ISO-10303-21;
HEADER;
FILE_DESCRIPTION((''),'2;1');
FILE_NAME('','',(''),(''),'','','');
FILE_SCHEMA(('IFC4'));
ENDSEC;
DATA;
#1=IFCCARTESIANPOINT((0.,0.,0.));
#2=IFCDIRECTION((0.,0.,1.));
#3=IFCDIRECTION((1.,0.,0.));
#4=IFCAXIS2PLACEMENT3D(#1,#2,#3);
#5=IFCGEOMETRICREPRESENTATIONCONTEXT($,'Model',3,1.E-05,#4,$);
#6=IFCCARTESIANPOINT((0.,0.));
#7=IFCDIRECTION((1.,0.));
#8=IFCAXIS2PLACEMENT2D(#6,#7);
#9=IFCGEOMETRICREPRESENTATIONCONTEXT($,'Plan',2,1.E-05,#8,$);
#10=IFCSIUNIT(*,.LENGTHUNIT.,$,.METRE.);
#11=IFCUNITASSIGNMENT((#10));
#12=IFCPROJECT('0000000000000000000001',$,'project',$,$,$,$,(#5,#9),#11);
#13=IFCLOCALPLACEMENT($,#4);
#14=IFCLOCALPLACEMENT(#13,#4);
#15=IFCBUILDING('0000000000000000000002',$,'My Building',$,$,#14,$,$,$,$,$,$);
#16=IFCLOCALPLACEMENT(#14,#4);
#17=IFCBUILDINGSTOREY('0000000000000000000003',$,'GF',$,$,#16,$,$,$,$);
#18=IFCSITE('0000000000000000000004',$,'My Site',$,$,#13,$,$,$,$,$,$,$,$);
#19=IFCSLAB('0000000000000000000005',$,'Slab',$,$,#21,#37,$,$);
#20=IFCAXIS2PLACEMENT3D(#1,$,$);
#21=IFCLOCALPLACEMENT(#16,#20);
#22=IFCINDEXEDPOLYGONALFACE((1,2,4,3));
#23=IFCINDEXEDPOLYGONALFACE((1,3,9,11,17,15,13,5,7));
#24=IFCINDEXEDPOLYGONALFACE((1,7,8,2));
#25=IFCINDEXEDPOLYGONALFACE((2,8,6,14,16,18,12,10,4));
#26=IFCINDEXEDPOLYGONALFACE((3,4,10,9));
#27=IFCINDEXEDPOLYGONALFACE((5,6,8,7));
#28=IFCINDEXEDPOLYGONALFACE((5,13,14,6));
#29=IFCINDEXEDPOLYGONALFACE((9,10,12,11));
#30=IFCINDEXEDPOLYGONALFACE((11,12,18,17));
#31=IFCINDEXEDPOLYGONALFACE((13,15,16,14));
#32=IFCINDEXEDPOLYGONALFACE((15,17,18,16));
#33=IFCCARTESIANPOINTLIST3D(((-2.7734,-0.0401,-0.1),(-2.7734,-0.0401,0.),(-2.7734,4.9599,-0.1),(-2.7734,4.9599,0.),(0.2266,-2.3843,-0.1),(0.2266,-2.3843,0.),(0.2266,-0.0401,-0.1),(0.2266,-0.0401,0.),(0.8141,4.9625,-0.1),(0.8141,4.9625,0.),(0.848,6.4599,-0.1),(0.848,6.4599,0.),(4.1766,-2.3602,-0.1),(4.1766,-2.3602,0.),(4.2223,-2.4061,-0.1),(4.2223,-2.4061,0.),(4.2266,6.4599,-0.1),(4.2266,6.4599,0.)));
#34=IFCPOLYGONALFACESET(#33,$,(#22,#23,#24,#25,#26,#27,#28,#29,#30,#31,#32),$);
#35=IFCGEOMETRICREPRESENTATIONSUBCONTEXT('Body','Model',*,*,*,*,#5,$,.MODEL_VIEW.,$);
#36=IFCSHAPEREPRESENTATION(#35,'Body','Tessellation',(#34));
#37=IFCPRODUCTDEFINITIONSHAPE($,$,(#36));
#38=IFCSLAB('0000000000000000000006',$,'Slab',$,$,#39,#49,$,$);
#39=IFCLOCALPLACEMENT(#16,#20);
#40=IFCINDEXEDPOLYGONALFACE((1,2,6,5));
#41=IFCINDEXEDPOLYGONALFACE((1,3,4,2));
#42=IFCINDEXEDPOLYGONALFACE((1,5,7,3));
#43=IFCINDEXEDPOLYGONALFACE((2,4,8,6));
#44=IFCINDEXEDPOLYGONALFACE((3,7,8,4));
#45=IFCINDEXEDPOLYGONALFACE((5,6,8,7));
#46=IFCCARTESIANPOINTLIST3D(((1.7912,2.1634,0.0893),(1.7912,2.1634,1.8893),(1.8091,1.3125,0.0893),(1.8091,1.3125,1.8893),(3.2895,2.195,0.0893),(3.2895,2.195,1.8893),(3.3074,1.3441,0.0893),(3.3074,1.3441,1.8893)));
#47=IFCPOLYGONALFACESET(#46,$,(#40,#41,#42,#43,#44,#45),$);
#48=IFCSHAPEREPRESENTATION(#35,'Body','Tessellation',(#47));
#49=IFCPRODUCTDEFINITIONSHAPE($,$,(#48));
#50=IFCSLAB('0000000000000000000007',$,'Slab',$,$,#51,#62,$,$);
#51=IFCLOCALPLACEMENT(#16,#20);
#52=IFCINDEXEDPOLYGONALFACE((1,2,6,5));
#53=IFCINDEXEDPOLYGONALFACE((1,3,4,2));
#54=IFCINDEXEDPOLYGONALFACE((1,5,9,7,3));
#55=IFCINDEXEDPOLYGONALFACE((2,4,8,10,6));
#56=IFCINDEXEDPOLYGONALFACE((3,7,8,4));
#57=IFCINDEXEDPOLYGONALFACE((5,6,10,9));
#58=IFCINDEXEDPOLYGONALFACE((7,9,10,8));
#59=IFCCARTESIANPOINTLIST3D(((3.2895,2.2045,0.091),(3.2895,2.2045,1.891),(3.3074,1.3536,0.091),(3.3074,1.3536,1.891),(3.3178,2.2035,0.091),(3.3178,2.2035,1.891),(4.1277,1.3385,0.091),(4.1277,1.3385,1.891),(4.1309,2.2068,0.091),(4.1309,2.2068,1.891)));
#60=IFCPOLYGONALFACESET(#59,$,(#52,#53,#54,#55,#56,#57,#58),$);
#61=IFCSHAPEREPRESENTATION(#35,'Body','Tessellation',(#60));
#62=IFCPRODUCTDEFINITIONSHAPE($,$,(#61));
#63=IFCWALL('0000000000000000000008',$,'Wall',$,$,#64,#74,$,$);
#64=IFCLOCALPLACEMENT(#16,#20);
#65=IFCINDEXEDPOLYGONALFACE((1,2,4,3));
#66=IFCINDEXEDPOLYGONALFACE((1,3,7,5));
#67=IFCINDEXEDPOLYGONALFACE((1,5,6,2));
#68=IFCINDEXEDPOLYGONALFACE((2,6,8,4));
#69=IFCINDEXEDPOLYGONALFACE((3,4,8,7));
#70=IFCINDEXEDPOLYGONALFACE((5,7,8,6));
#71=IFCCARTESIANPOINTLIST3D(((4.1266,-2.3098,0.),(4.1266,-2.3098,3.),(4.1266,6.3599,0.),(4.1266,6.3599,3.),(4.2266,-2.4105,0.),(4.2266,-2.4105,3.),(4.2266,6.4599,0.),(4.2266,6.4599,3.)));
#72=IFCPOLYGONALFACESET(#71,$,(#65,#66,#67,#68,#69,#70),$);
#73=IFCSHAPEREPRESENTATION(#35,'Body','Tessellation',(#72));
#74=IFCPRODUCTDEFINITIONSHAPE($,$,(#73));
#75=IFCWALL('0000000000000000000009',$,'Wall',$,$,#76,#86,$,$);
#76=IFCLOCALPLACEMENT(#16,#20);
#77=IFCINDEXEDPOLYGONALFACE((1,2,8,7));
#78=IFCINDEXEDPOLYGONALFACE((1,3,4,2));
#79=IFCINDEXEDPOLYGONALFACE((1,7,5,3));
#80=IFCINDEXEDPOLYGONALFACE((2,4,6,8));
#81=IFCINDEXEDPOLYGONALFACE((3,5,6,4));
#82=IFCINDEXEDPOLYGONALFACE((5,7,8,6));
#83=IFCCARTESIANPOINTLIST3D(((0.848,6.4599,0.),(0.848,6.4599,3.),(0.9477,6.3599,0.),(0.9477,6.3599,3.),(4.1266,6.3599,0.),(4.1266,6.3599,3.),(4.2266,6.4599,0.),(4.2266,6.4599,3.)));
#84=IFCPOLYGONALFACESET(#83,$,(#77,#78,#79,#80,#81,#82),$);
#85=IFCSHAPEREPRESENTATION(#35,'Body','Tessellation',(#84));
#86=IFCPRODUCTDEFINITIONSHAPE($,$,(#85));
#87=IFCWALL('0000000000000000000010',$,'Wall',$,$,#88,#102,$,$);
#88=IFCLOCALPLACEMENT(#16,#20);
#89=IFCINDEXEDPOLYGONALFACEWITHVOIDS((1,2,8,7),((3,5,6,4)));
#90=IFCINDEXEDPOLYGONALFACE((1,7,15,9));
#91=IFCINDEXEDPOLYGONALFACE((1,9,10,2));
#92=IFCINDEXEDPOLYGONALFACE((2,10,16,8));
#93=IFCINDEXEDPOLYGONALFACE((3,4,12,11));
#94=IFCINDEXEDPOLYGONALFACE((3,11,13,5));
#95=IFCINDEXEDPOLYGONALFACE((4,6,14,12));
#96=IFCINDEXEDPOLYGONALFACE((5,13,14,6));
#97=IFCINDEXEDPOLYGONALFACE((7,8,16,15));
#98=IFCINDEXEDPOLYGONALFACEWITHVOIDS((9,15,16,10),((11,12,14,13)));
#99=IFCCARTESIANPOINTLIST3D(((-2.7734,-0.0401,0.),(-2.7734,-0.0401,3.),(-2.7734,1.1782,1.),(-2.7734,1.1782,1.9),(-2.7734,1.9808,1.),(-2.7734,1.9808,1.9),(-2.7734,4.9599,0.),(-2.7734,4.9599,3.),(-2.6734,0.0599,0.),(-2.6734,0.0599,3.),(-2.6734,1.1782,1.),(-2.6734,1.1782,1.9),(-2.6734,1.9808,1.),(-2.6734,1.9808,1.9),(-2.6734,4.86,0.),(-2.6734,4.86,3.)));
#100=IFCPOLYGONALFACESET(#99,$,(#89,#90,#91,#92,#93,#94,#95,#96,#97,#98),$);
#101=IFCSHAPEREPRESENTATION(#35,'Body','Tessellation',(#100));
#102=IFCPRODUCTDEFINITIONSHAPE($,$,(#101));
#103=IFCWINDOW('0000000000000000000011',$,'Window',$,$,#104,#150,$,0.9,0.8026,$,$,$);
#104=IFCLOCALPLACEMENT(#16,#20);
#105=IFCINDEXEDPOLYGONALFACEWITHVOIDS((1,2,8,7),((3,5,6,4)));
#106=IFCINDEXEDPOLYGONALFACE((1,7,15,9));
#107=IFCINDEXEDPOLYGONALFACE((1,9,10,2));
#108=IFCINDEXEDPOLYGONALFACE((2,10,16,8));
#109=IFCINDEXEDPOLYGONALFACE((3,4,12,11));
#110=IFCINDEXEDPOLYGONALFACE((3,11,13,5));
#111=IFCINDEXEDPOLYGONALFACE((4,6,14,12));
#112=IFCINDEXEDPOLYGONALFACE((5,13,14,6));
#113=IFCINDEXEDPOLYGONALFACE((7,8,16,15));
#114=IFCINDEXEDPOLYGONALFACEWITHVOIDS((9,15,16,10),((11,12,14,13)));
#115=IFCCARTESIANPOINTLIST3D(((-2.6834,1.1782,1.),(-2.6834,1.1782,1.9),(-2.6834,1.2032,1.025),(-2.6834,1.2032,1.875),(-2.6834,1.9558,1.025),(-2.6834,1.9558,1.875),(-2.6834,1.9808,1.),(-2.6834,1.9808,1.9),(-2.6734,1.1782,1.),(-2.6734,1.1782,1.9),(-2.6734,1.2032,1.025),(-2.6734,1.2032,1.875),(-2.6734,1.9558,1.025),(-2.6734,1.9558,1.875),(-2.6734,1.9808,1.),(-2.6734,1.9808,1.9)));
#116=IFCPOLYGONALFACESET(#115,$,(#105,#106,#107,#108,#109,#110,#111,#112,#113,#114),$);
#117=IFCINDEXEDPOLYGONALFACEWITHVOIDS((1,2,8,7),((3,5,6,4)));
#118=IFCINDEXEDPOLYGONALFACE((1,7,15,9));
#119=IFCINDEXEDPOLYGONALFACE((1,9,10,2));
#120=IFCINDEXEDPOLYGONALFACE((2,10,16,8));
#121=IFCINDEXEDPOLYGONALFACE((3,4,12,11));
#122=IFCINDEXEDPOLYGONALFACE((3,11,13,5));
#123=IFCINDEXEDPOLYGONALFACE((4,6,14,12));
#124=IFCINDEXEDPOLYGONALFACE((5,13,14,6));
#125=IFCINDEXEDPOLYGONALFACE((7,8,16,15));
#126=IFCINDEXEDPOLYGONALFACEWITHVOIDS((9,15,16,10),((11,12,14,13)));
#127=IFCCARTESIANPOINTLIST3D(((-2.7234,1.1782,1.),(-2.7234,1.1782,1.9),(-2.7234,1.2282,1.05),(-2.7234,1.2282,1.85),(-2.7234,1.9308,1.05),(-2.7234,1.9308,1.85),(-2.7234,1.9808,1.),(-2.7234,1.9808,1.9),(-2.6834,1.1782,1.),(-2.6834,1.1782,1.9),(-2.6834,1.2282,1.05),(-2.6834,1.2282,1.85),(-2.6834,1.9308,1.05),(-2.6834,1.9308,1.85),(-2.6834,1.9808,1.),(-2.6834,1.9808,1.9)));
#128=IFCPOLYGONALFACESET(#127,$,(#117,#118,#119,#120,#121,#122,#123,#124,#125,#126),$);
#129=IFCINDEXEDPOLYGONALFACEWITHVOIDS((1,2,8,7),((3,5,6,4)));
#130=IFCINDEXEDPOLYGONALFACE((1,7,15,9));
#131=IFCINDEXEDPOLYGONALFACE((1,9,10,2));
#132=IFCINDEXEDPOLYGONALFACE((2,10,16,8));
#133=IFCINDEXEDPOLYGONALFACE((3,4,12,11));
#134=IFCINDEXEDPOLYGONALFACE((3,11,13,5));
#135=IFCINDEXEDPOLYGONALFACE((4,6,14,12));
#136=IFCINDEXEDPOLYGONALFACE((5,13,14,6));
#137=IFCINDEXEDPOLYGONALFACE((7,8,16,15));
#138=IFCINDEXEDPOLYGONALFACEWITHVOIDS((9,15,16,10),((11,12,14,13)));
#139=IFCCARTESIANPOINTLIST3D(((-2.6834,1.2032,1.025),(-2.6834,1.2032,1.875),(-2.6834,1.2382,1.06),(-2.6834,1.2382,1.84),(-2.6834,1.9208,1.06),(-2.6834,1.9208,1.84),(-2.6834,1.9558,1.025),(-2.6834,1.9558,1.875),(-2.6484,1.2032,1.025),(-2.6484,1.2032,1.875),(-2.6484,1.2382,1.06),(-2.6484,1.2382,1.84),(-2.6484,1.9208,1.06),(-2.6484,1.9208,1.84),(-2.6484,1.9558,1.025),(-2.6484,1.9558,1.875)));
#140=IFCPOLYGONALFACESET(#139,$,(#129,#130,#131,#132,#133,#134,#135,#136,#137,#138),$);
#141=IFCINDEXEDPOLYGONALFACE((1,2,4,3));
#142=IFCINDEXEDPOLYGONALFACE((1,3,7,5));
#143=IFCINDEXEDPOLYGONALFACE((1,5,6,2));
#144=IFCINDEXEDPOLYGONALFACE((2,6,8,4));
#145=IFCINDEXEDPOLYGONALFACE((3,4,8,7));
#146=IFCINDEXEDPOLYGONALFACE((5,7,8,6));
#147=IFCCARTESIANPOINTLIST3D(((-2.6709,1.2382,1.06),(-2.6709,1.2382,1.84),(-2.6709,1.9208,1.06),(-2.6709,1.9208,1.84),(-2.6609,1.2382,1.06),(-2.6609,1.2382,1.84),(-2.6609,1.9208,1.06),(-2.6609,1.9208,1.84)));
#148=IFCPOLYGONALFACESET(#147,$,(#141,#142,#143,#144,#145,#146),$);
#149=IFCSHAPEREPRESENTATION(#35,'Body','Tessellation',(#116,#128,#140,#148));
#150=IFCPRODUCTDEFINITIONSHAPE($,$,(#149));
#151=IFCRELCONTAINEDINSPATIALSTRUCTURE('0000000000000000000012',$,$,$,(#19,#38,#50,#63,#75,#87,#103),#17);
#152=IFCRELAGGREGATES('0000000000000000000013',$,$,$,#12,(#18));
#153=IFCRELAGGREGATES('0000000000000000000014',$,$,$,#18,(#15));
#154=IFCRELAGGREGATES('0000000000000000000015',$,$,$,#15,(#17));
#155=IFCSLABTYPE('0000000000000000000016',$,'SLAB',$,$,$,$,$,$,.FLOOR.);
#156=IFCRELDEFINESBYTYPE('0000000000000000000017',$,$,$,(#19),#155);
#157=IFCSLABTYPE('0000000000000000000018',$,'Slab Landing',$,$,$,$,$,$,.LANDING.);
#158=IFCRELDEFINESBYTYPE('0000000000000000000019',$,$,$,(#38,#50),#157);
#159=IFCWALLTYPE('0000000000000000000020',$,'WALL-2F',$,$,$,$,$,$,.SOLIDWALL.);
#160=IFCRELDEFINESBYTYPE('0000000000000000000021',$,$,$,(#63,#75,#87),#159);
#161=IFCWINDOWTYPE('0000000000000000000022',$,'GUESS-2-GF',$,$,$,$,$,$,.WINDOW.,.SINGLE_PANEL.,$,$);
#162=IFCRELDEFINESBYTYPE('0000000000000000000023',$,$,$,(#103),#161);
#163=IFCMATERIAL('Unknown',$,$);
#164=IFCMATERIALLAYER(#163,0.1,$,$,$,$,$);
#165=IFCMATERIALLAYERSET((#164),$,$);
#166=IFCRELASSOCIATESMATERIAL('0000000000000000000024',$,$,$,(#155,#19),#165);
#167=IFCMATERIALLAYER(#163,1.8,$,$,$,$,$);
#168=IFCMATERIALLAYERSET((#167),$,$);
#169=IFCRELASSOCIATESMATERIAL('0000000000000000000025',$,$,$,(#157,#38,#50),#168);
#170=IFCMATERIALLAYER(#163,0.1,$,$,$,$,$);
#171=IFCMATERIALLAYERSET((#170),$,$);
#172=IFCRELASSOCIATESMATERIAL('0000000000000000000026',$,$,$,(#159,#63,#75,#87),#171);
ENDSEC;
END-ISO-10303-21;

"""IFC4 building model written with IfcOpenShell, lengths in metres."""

from ifc_helpers import new_model, entity, si_unit, frame, origin_with_axes, origin_2d_with_axis, place, context, subcontext, project, spatial, line, indexed_curve, outline, extrude, shape, source, transform, mapped, material, layer, layer_set, layer_usage, type_object, type_shapes, element, fill, save


model = new_model("IFC4")

# Units and contexts
model_context = context("Model", 3, precision=1e-05, world=origin_with_axes())
plan_context = context("Plan", 2, precision=1e-05, world=origin_2d_with_axis())
body_context_1 = subcontext(model_context, "Body", "Model", "MODEL_VIEW")
body_context_2 = subcontext(plan_context, "Body", "Plan", "PLAN_VIEW")
ifc_project = project(units=[si_unit("LENGTHUNIT", "METRE")], contexts=[model_context, plan_context])

# Site, building, storey
site_placement = place(None, origin_with_axes())
site = spatial("IfcSite", under=ifc_project, at=site_placement, Name="My Site")
building_placement = place(site_placement, origin_with_axes())
building = spatial("IfcBuilding", under=site, at=building_placement, Name="My Building")
storey_placement = place(building_placement, origin_with_axes())
storey = spatial("IfcBuildingStorey", under=building, at=storey_placement, Name="GF")

# Slabs
ifc_material_1 = material(Name="Unknown")
ifc_layer_1 = layer(ifc_material_1, 0.1)
ifc_layer_set_1 = layer_set([ifc_layer_1])
ifc_layer_usage_1 = layer_usage(ifc_layer_set_1, "AXIS3", "POSITIVE", -0.1)
slab_type_1 = type_object("IfcSlabType", Name="SLAB", PredefinedType="FLOOR", material=ifc_layer_set_1)
slab_1_placement = place(storey_placement, frame((4.2223, -2.4061, 0.0), z_axis=(0.0, 0.0, 1.0), x_axis=(1.0, 0.0, 0.0)))
element("IfcSlab", 1, at=slab_1_placement, inside=storey, type_object=slab_type_1, material=ifc_layer_usage_1, Name="Slab", context=body_context_1, shape_type="SweptSolid", body=[
    extrude(outline(indexed_curve([(0.0, 0.0), (0.0043, 8.866), (-3.3742, 8.866), (-3.4082, 7.3687), (-6.9957, 7.366), (-6.9957, 2.366), (-3.9957, 2.366), (-3.9957, 0.0219), (-0.0457, 0.046), (0.0, 0.0)])), frame((0.0, 0.0, -0.1), z_axis=(0.0, 0.0, 1.0), x_axis=(1.0, 0.0, 0.0)), (0.0, 0.0, 1.0), 0.1),
])
ifc_layer_2 = layer(ifc_material_1, 1.8)
ifc_layer_set_2 = layer_set([ifc_layer_2])
slab_type_2 = type_object("IfcSlabType", Name="Slab Landing", PredefinedType="LANDING", material=ifc_layer_set_2)
ifc_layer_usage_2 = layer_usage(ifc_layer_set_2, "AXIS3", "POSITIVE", -1.8)
slab_2_placement = place(storey_placement, frame((3.2895, 2.195, 1.8893), z_axis=(0.0, 0.0, 1.0), x_axis=(1.0, 0.0, 0.0)))
element("IfcSlab", 2, at=slab_2_placement, inside=storey, type_object=slab_type_2, material=ifc_layer_usage_2, Name="Slab", context=body_context_1, shape_type="SweptSolid", body=[
    extrude(outline(indexed_curve([(0.0, 0.0), (0.0179, -0.8509), (-1.4804, -0.8824), (-1.4983, -0.0315), (0.0, 0.0)])), frame((0.0, 0.0, -1.8), z_axis=(0.0, 0.0, 1.0), x_axis=(1.0, 0.0, 0.0)), (0.0, 0.0, 1.0), 1.8),
])
ifc_layer_usage_3 = layer_usage(ifc_layer_set_2, "AXIS3", "POSITIVE", -1.8)
slab_3_placement = place(storey_placement, frame((3.3178, 2.2035, 1.891), z_axis=(0.0, 0.0, 1.0), x_axis=(1.0, 0.0, 0.0)))
element("IfcSlab", 3, at=slab_3_placement, inside=storey, type_object=slab_type_2, material=ifc_layer_usage_3, Name="Slab", context=body_context_1, shape_type="SweptSolid", body=[
    extrude(outline(indexed_curve([(0.0, 0.0), (0.8131, 0.0032), (0.8098, -0.865), (-0.0104, -0.8499), (-0.0284, 0.001), (0.0, 0.0)])), frame((0.0, 0.0, -1.8), z_axis=(0.0, 0.0, 1.0), x_axis=(1.0, 0.0, 0.0)), (0.0, 0.0, 1.0), 1.8),
])

# Walls
ifc_layer_3 = layer(ifc_material_1, 0.1)
ifc_layer_set_3 = layer_set([ifc_layer_3])
ifc_layer_usage_4 = layer_usage(ifc_layer_set_3, "AXIS2", "POSITIVE", 0.0)
wall_type_1 = type_object("IfcWallType", Name="WALL-2F", PredefinedType="SOLIDWALL", material=ifc_layer_set_3)
wall_1_placement = place(storey_placement, frame((4.2266, -2.4105, 0.0), z_axis=(0.0, 0.0, 1.0), x_axis=(0.0, 1.0, 0.0)))
element("IfcWall", 4, at=wall_1_placement, inside=storey, type_object=wall_type_1, material=ifc_layer_usage_4, Name="Wall", context=body_context_1, shape_type="SweptSolid", body=[
    extrude(outline(indexed_curve([(0.0, 0.0), (0.1007, 0.1), (8.7704, 0.1), (8.8704, 0.0)], segments=[line(1, 2, 3, 4, 1)])), origin_with_axes(), (0.0, 0.0, 1.0), 3.0),
])
ifc_layer_usage_5 = layer_usage(ifc_layer_set_3, "AXIS2", "POSITIVE", 0.0)
wall_2_placement = place(storey_placement, frame((4.2266, 6.4599, 0.0), z_axis=(0.0, 0.0, 1.0), x_axis=(-1.0, 0.0, 0.0)))
element("IfcWall", 5, at=wall_2_placement, inside=storey, type_object=wall_type_1, material=ifc_layer_usage_5, Name="Wall", context=body_context_1, shape_type="SweptSolid", body=[
    extrude(outline(indexed_curve([(0.0, 0.0), (0.1, 0.1), (3.2789, 0.1), (3.3786, 0.0)], segments=[line(1, 2, 3, 4, 1)])), origin_with_axes(), (0.0, 0.0, 1.0), 3.0),
])

# Wall, opening, window
ifc_layer_usage_6 = layer_usage(ifc_layer_set_3, "AXIS2", "POSITIVE", 0.0)
wall_3_placement = place(storey_placement, frame((-2.7734, 4.8599, 0.0), z_axis=(0.0, 0.0, 1.0), x_axis=(0.0, -1.0, 0.0)))
wall_3 = element("IfcWall", 6, at=wall_3_placement, inside=storey, type_object=wall_type_1, material=ifc_layer_usage_6, Name="Wall", context=body_context_1, shape_type="SweptSolid", body=[
    extrude(outline(indexed_curve([(-0.1, 0.0), (-0.0001, 0.1), (4.8, 0.1), (4.9, 0.0)], segments=[line(1, 2, 3, 4, 1)])), origin_with_axes(), (0.0, 0.0, 1.0), 3.0),
])
shared_shape_1 = source(origin_with_axes(), body_context_1, "Body", "SweptSolid", [
    extrude(outline(indexed_curve([(0.0, 0.0), (0.8026, 0.0), (0.8026, 0.9), (0.0, 0.9)], segments=[line(1, 2, 3, 4, 1)])), frame((0.0, -0.6, 0.0), z_axis=(0.0, -1.0, 0.0), x_axis=(1.0, 0.0, 0.0)), (0.0, 0.0, -1.0), 1.2),
])
opening_1_placement = place(wall_3_placement, frame((2.8791, 0.0, 1.0), z_axis=(0.0, 0.0, 1.0), x_axis=(1.0, 0.0, 0.0)))
opening_1 = element("IfcOpeningElement", 7, at=opening_1_placement, cuts=wall_3, PredefinedType="OPENING", context=body_context_1, shape_type="MappedRepresentation", body=[
    mapped(shared_shape_1, transform((0.0, 0.0, 0.0), x_axis=(1.0, 0.0, 0.0), y_axis=(0.0, 1.0, 0.0), z_axis=(0.0, 0.0, 1.0), scale=1.0)),
])
window_type_1 = type_object("IfcWindowType", Name="GUESS-2-GF", PartitioningType="SINGLE_PANEL", PredefinedType="WINDOW")
shared_shape_2 = source(origin_with_axes(), body_context_1, "Body", "SweptSolid", [
    extrude(outline(indexed_curve([(0.0, 0.0), (0.8026, 0.0), (0.8026, 0.9), (0.0, 0.9)], segments=[line(1, 2, 3, 4, 1)]), holes=[indexed_curve([(0.025, 0.025), (0.7776, 0.025), (0.7776, 0.875), (0.025, 0.875)], segments=[line(1, 2, 3, 4, 1)])]), frame((0.0, 0.09, 0.0), z_axis=(0.0, -1.0, 0.0), x_axis=(1.0, 0.0, 0.0)), (0.0, 0.0, -1.0), 0.01),
    extrude(outline(indexed_curve([(0.0, 0.0), (0.8026, 0.0), (0.8026, 0.9), (0.0, 0.9)], segments=[line(1, 2, 3, 4, 1)]), holes=[indexed_curve([(0.05, 0.05), (0.7526, 0.05), (0.7526, 0.85), (0.05, 0.85)], segments=[line(1, 2, 3, 4, 1)])]), frame((0.0, 0.05, 0.0), z_axis=(0.0, -1.0, 0.0), x_axis=(1.0, 0.0, 0.0)), (0.0, 0.0, -1.0), 0.04),
    extrude(outline(indexed_curve([(0.0, 0.0), (0.7526, 0.0), (0.7526, 0.85), (0.0, 0.85)], segments=[line(1, 2, 3, 4, 1)]), holes=[indexed_curve([(0.035, 0.035), (0.7176, 0.035), (0.7176, 0.815), (0.035, 0.815)], segments=[line(1, 2, 3, 4, 1)])]), frame((0.025, 0.09, 0.025), z_axis=(0.0, -1.0, 0.0), x_axis=(1.0, 0.0, 0.0)), (0.0, 0.0, -1.0), 0.035),
    extrude(outline(indexed_curve([(0.035, 0.035), (0.7176, 0.035), (0.7176, 0.815), (0.035, 0.815)], segments=[line(1, 2, 3, 4, 1)])), frame((0.025, 0.1025, 0.025), z_axis=(0.0, -1.0, 0.0), x_axis=(1.0, 0.0, 0.0)), (0.0, 0.0, -1.0), 0.01),
])
shared_shape_3 = source(origin_with_axes(), body_context_2, "Body", "Curve2D", [
    entity("IfcIndexedPolyCurve", entity("IfcCartesianPointList2D", [[0.05, 0.05], [0.7526, 0.05]])),
    entity("IfcIndexedPolyCurve", entity("IfcCartesianPointList2D", [[0.0, 0.1], [0.025, 0.1], [0.025, 0.09], [0.05, 0.09], [0.05, 0.05], [0.0, 0.05]]), [entity("IfcLineIndex", [1, 2, 3, 4, 5, 6, 1])]),
    entity("IfcIndexedPolyCurve", entity("IfcCartesianPointList2D", [[0.8026, 0.1], [0.7776, 0.1], [0.7776, 0.09], [0.7526, 0.09], [0.7526, 0.05], [0.8026, 0.05]]), [entity("IfcLineIndex", [1, 2, 3, 4, 5, 6, 1])]),
    entity("IfcIndexedPolyCurve", entity("IfcCartesianPointList2D", [[0.025, 0.09], [0.06, 0.09], [0.06, 0.125], [0.025, 0.125]]), [entity("IfcLineIndex", [1, 2, 3, 4, 1])]),
    entity("IfcIndexedPolyCurve", entity("IfcCartesianPointList2D", [[0.7776, 0.09], [0.7426, 0.09], [0.7426, 0.125], [0.7776, 0.125]]), [entity("IfcLineIndex", [1, 2, 3, 4, 1])]),
    entity("IfcIndexedPolyCurve", entity("IfcCartesianPointList2D", [[0.06, 0.09], [0.7426, 0.09]])),
    entity("IfcIndexedPolyCurve", entity("IfcCartesianPointList2D", [[0.06, 0.125], [0.7426, 0.125]])),
    entity("IfcIndexedPolyCurve", entity("IfcCartesianPointList2D", [[0.06, 0.1075], [0.7426, 0.1075]])),
])
type_shapes(window_type_1, [shared_shape_2, shared_shape_3])
window_1_placement = place(opening_1_placement, frame((0.0, 0.0, 0.0), z_axis=(0.0, 0.0, 1.0), x_axis=(1.0, 0.0, 0.0)))
window_1 = element("IfcWindow", 8, at=window_1_placement, inside=storey, type_object=window_type_1, Name="Window", OverallHeight=0.9, OverallWidth=0.8026, shapes=[
    shape(body_context_1, "Body", "MappedRepresentation", [mapped(shared_shape_2, transform((0.0, 0.0, 0.0), x_axis=(1.0, 0.0, 0.0), y_axis=(0.0, 1.0, 0.0), z_axis=(0.0, 0.0, 1.0), scale=1.0))]),
    shape(body_context_2, "Body", "MappedRepresentation", [mapped(shared_shape_3, transform((0.0, 0.0, 0.0), x_axis=(1.0, 0.0, 0.0), y_axis=(0.0, 1.0, 0.0), z_axis=(0.0, 0.0, 1.0), scale=1.0))]),
])
fill(opening_1, window_1)

save(model, "model.ifc")
